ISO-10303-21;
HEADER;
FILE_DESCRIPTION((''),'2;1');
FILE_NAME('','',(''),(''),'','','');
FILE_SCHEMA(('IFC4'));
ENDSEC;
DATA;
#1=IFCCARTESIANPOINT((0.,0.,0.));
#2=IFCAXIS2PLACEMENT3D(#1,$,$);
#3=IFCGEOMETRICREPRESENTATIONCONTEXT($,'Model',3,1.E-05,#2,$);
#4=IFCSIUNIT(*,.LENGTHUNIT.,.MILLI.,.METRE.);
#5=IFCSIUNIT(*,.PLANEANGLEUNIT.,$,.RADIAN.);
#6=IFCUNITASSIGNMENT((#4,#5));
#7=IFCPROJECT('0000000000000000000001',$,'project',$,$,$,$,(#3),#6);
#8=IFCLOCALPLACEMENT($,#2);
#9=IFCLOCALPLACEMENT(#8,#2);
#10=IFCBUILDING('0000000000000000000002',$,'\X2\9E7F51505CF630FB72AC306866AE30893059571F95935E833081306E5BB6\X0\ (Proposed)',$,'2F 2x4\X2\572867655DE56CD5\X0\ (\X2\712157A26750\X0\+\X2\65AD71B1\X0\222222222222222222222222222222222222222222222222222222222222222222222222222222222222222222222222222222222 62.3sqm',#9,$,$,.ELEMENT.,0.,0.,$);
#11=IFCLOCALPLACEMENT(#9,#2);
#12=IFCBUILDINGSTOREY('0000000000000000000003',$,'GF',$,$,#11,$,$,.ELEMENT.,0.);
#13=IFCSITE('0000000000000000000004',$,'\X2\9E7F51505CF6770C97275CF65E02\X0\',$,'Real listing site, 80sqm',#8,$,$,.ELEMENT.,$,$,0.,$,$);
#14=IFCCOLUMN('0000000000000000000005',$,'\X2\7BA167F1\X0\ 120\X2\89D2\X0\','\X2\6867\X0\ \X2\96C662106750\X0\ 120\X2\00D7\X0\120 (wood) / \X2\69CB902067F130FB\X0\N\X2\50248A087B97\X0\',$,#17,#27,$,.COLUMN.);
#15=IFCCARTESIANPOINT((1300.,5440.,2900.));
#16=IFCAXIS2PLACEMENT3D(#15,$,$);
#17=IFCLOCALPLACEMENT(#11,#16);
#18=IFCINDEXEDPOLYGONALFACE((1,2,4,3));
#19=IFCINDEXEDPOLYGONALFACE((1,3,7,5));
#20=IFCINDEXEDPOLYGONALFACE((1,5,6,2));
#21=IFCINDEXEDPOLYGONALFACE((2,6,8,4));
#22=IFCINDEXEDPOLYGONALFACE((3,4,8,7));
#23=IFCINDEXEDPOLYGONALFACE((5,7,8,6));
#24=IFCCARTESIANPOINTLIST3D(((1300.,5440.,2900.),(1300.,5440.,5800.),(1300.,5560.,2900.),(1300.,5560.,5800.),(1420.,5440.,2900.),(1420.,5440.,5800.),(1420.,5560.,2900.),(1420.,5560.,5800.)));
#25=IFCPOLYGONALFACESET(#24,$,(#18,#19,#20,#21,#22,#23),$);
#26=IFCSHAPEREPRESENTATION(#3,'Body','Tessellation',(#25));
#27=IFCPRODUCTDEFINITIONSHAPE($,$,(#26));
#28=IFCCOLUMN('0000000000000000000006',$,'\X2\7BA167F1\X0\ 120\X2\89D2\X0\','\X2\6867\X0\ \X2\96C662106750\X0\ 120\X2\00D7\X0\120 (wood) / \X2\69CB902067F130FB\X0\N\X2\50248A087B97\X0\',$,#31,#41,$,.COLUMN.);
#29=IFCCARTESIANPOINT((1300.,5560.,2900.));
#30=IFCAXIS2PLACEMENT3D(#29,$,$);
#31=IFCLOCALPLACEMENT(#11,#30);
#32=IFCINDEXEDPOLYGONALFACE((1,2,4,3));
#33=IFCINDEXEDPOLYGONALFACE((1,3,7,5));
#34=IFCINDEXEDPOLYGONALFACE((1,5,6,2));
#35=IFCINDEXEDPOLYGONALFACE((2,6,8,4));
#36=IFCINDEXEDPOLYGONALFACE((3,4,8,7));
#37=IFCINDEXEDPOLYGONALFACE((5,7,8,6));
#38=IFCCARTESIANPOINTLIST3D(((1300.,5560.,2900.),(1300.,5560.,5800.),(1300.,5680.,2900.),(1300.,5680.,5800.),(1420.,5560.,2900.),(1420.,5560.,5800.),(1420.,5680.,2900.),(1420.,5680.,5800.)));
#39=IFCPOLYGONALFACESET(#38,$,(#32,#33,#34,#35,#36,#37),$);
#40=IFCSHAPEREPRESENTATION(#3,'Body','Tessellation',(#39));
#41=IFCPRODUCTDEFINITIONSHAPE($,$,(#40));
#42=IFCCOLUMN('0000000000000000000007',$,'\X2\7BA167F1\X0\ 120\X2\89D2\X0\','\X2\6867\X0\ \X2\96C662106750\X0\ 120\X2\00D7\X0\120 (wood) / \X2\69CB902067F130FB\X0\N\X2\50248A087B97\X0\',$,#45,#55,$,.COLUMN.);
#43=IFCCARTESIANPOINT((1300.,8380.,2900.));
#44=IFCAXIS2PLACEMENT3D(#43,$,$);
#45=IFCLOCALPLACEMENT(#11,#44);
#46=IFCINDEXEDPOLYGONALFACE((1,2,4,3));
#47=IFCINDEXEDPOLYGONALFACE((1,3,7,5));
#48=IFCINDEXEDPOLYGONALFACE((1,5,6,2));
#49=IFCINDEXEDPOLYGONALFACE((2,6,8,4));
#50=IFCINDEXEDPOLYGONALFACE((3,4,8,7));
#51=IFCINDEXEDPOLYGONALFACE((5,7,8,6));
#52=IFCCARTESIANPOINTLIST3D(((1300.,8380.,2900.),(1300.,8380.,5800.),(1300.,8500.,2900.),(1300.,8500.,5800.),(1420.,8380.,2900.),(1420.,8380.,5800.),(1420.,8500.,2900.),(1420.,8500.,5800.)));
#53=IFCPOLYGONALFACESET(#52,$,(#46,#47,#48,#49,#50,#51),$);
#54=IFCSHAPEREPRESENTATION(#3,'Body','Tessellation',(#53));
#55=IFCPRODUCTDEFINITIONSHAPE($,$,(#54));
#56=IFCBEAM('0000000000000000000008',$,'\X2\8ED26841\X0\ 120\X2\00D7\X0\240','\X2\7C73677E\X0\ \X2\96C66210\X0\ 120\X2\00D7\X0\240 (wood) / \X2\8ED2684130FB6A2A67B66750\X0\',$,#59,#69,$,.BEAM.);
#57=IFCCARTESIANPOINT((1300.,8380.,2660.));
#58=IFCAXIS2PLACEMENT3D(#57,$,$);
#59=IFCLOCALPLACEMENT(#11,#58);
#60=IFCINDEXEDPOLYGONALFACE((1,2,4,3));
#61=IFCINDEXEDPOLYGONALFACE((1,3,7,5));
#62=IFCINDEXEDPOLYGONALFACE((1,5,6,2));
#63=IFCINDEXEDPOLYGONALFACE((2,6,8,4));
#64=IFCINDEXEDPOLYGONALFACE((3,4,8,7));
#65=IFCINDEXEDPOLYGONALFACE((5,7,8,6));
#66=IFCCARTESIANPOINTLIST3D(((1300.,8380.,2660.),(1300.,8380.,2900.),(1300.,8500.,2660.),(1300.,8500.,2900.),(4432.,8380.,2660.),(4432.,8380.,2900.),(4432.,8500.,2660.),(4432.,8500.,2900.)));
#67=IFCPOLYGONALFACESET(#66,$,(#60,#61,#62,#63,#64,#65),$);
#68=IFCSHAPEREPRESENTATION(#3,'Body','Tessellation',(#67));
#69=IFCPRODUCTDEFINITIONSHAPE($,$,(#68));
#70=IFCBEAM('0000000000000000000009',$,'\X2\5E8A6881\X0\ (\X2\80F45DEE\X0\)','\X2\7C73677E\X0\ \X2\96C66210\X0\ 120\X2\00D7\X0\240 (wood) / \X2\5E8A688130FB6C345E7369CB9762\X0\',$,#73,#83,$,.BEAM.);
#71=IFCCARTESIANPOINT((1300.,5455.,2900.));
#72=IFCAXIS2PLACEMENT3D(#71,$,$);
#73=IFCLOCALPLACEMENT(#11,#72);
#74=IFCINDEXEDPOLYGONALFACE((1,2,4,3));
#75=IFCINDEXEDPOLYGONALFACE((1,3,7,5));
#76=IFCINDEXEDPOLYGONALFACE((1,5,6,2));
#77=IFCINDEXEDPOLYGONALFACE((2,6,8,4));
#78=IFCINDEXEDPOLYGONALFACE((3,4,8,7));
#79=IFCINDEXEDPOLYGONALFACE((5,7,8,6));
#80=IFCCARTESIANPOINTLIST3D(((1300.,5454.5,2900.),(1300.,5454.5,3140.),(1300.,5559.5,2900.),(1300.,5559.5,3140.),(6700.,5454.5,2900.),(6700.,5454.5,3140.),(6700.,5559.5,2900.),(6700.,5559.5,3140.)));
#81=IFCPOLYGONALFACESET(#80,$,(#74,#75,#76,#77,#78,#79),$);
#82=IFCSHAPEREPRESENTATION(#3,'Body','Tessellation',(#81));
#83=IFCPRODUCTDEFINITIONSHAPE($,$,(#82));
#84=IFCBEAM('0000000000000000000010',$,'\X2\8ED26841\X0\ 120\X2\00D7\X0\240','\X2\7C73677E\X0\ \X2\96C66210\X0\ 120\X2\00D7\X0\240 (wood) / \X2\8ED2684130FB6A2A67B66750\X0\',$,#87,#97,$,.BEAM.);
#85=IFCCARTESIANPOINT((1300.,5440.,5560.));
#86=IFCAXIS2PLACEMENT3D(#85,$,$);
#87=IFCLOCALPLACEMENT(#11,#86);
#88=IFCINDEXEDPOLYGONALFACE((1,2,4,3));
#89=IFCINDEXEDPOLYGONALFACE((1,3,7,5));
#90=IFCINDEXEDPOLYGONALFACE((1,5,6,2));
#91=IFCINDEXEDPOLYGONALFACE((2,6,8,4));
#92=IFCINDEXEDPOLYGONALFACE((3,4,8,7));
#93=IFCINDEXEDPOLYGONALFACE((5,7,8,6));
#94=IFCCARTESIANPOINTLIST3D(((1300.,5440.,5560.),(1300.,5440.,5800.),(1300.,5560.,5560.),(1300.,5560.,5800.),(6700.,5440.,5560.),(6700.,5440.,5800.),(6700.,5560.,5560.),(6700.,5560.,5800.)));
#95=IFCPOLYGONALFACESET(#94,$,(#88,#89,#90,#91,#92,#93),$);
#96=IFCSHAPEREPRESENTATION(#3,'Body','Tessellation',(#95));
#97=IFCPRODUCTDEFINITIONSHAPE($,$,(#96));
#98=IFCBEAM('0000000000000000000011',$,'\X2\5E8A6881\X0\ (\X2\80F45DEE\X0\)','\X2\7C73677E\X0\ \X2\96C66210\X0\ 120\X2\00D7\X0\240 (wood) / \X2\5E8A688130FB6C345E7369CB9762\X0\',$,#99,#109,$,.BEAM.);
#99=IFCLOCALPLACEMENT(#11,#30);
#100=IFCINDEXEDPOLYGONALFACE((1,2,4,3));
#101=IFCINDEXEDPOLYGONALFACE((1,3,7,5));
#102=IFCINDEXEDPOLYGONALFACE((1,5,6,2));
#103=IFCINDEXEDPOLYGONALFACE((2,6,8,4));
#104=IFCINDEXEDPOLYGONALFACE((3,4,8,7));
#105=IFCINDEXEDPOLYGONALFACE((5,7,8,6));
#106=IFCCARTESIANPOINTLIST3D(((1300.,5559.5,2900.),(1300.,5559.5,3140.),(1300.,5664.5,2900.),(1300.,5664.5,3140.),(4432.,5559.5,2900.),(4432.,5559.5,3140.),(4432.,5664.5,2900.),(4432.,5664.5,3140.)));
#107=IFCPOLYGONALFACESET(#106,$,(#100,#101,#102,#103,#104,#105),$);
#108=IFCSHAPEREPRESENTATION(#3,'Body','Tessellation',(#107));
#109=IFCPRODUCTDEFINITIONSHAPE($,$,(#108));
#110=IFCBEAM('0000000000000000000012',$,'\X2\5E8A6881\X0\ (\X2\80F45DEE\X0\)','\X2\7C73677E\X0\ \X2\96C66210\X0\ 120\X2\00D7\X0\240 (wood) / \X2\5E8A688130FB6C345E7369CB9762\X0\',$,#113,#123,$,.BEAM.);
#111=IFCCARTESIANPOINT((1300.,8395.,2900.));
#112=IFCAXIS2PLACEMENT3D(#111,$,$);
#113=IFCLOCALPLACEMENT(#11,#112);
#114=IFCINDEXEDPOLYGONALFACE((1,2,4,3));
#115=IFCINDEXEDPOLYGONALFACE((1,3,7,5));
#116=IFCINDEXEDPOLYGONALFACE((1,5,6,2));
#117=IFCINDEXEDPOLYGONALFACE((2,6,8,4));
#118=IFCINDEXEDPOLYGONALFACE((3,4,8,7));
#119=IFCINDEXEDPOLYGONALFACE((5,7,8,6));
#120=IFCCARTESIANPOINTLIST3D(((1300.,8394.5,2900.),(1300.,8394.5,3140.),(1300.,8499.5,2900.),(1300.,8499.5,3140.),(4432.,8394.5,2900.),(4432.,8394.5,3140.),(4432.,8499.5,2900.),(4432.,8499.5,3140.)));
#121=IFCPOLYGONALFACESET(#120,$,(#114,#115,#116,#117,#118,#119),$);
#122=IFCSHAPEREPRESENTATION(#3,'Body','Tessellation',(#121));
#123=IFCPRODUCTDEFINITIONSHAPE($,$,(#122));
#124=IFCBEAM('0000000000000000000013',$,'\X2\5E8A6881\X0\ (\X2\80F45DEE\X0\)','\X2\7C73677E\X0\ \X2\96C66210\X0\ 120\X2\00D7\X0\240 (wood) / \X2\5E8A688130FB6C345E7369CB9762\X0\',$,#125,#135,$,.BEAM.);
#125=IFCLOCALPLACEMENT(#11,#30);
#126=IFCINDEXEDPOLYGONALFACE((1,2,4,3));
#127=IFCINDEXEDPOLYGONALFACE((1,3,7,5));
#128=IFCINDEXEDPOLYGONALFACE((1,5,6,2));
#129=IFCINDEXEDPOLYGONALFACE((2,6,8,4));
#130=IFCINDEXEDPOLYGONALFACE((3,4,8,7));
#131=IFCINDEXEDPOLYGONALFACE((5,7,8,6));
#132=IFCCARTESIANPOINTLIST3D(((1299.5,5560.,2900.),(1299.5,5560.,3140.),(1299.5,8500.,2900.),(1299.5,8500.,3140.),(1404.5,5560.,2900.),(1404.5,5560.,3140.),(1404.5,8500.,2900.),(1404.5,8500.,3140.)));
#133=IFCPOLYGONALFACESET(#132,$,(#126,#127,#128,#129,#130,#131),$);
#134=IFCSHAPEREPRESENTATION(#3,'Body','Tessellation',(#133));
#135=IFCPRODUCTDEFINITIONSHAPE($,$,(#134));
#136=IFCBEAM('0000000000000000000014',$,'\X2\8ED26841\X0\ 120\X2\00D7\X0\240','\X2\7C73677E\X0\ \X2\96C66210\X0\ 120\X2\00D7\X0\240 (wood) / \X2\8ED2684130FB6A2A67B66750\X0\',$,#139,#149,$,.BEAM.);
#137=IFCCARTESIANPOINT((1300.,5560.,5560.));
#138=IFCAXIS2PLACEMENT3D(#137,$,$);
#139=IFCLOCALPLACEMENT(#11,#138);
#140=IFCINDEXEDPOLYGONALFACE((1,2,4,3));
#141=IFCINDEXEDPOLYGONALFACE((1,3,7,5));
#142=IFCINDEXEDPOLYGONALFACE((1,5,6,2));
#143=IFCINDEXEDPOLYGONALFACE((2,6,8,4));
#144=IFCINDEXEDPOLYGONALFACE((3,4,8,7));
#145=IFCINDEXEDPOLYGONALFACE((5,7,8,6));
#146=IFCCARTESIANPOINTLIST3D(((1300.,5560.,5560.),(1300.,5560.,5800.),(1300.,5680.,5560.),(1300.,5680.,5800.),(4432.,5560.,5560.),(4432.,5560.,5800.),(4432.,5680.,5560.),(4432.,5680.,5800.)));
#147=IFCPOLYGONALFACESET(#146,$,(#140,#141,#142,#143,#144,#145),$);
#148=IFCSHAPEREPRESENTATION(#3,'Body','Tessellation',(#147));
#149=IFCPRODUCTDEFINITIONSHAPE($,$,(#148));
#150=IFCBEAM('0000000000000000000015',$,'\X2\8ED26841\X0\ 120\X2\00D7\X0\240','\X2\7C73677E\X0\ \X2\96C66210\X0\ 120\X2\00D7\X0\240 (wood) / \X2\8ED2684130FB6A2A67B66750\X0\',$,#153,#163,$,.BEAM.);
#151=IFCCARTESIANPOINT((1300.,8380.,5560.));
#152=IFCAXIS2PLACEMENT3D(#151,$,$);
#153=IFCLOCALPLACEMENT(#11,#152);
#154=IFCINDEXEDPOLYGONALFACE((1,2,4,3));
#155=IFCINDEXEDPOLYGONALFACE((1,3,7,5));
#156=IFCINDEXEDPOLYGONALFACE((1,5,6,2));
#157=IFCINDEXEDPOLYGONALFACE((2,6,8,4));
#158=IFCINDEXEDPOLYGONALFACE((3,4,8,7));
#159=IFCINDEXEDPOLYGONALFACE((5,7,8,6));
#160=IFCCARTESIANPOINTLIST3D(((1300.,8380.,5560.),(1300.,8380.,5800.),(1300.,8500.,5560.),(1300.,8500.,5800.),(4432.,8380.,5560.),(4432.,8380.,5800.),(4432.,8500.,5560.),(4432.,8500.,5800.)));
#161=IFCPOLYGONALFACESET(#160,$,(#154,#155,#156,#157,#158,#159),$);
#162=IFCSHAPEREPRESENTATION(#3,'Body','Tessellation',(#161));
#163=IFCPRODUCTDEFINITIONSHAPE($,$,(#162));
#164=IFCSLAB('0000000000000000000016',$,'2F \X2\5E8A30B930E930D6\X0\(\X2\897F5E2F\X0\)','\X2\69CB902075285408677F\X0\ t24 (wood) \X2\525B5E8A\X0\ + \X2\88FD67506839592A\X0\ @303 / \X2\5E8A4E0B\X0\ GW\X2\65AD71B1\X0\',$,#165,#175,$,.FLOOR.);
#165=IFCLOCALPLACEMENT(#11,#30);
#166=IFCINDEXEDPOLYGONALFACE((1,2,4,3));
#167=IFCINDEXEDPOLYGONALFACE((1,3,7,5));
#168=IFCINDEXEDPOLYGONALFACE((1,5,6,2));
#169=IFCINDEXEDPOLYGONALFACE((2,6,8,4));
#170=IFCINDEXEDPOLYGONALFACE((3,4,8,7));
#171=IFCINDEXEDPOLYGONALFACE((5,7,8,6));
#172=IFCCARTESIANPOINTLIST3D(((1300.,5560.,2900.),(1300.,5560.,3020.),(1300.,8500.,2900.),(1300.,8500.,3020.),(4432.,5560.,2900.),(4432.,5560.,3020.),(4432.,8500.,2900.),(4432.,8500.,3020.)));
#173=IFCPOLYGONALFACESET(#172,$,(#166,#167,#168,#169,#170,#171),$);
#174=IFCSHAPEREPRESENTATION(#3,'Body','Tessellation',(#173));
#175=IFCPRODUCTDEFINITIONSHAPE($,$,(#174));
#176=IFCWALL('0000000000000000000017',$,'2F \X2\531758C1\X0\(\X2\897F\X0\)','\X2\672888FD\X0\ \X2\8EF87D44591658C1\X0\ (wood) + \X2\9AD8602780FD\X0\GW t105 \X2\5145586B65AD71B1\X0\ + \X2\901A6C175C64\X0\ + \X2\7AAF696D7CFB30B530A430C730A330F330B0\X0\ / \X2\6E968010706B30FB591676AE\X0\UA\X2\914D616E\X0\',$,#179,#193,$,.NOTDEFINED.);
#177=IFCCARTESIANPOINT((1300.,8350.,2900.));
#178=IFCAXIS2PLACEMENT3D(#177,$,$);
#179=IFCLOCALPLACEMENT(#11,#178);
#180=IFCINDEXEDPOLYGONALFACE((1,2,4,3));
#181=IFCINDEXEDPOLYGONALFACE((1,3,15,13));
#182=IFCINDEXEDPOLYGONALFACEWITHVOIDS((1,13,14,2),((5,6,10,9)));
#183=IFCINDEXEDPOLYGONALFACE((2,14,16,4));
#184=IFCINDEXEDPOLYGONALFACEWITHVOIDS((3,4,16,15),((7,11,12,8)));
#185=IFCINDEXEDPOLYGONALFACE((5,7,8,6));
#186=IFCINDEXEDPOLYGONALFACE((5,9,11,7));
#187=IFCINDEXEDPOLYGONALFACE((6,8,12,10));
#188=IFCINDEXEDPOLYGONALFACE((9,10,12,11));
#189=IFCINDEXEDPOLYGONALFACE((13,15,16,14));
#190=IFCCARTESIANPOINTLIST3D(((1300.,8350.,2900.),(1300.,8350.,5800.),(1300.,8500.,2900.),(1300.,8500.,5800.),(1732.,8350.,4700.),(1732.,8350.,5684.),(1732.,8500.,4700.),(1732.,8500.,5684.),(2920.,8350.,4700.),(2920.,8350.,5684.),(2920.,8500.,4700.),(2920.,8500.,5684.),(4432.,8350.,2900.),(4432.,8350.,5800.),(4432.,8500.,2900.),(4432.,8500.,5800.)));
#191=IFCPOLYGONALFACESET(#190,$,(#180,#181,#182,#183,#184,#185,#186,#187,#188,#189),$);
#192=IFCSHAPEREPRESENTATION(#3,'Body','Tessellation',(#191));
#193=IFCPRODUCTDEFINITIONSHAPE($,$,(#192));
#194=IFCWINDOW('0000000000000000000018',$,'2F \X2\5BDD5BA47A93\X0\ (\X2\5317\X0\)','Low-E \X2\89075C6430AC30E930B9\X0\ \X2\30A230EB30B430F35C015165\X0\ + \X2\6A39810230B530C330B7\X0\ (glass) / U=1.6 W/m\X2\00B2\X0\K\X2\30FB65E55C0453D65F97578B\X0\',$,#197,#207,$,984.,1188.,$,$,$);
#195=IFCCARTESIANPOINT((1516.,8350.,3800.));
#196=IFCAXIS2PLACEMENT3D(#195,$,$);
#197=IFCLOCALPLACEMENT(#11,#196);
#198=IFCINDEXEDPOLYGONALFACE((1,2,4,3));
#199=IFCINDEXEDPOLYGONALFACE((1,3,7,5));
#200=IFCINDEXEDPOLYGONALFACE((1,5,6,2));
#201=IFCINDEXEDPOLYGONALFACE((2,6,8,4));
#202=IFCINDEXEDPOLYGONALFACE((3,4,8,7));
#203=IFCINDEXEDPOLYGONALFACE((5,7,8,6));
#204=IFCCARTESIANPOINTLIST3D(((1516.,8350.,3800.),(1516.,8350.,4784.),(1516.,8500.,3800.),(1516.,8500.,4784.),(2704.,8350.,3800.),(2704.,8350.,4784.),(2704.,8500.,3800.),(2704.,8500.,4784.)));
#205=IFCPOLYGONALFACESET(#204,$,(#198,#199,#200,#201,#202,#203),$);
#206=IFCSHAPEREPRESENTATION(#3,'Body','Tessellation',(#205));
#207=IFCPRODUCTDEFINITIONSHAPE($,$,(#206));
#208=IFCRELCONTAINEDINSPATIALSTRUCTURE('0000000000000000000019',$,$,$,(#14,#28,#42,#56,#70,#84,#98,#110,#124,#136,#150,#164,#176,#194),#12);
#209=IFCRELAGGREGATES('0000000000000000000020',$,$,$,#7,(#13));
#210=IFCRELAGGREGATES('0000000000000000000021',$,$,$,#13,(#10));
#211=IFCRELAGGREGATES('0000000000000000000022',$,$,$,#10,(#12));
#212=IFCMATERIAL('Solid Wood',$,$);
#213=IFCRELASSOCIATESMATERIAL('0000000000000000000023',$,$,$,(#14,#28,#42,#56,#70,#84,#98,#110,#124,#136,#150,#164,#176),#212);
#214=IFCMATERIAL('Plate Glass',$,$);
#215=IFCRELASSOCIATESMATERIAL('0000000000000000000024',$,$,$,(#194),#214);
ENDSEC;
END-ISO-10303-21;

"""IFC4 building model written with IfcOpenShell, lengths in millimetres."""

from ifc_helpers import new_model, si_unit, frame, frame_2d, origin, place, context, project, spatial, rectangle, extrude, material, element, fill, save


model = new_model("IFC4")

# Units and contexts
model_context = context("Model", 3, precision=1e-05, world=origin())
ifc_project = project(units=[si_unit("LENGTHUNIT", "METRE", prefix="MILLI"), si_unit("PLANEANGLEUNIT", "RADIAN")], contexts=[model_context])

# Site, building, storey
site_placement = place(None, origin())
site = spatial("IfcSite", under=ifc_project, at=site_placement, Name="鹿児島県霧島市", ObjectType="Real listing site, 80sqm", CompositionType="ELEMENT", RefElevation=0.0)
building_placement = place(site_placement, origin())
building = spatial("IfcBuilding", under=site, at=building_placement, Name="鹿児島・犬と暮らす土間広めの家 (Proposed)", ObjectType="2F 2x4在来工法 (無垢材+断熱222222222222222222222222222222222222222222222222222222222222222222222222222222222222222222222222222222222 62.3sqm", CompositionType="ELEMENT", ElevationOfRefHeight=0.0, ElevationOfTerrain=0.0)
storey_placement = place(building_placement, origin())
storey = spatial("IfcBuildingStorey", under=building, at=storey_placement, Name="GF", CompositionType="ELEMENT", Elevation=0.0)

# Columns
ifc_material_1 = material(Name="Solid Wood")
column_1_placement = place(storey_placement, frame((1300.0, 5440.0, 2900.0)))
element("IfcColumn", 1, at=column_1_placement, inside=storey, material=ifc_material_1, Name="管柱 120角", Description="桧 集成材 120×120 (wood) / 構造柱・N値計算", PredefinedType="COLUMN", context=model_context, shape_type="SweptSolid", body=[
    extrude(rectangle(XDim=120.0, YDim=120.0, at=frame_2d((60.0, 60.0))), frame((1300.0, 5440.0, 2900.0)), (0.0, 0.0, 1.0), 2900.0),
])
column_2_placement = place(storey_placement, frame((1300.0, 5560.0, 2900.0)))
element("IfcColumn", 2, at=column_2_placement, inside=storey, material=ifc_material_1, Name="管柱 120角", Description="桧 集成材 120×120 (wood) / 構造柱・N値計算", PredefinedType="COLUMN", context=model_context, shape_type="SweptSolid", body=[
    extrude(rectangle(XDim=120.0, YDim=120.0, at=frame_2d((60.0, 60.0))), frame((1300.0, 5560.0, 2900.0)), (0.0, 0.0, 1.0), 2900.0),
])
column_3_placement = place(storey_placement, frame((1300.0, 8380.0, 2900.0)))
element("IfcColumn", 3, at=column_3_placement, inside=storey, material=ifc_material_1, Name="管柱 120角", Description="桧 集成材 120×120 (wood) / 構造柱・N値計算", PredefinedType="COLUMN", context=model_context, shape_type="SweptSolid", body=[
    extrude(rectangle(XDim=120.0, YDim=120.0, at=frame_2d((60.0, 60.0))), frame((1300.0, 8380.0, 2900.0)), (0.0, 0.0, 1.0), 2900.0),
])

# Beams
beam_1_placement = place(storey_placement, frame((1300.0, 8380.0, 2660.0)))
element("IfcBeam", 4, at=beam_1_placement, inside=storey, material=ifc_material_1, Name="軒桁 120×240", Description="米松 集成 120×240 (wood) / 軒桁・横架材", PredefinedType="BEAM", context=model_context, shape_type="SweptSolid", body=[
    extrude(rectangle(XDim=3132.0, YDim=120.0, at=frame_2d((1566.0, 60.0))), frame((1300.0, 8380.0, 2660.0)), (0.0, 0.0, 1.0), 240.0),
])
beam_2_placement = place(storey_placement, frame((1300.0, 5455.0, 2900.0)))
element("IfcBeam", 5, at=beam_2_placement, inside=storey, material=ifc_material_1, Name="床梁 (胴差)", Description="米松 集成 120×240 (wood) / 床梁・水平構面", PredefinedType="BEAM", context=model_context, shape_type="SweptSolid", body=[
    extrude(rectangle(XDim=5400.0, YDim=105.0, at=frame_2d((2700.0, 52.0))), frame((1300.0, 5455.0, 2900.0)), (0.0, 0.0, 1.0), 240.0),
])
beam_3_placement = place(storey_placement, frame((1300.0, 5440.0, 5560.0)))
element("IfcBeam", 6, at=beam_3_placement, inside=storey, material=ifc_material_1, Name="軒桁 120×240", Description="米松 集成 120×240 (wood) / 軒桁・横架材", PredefinedType="BEAM", context=model_context, shape_type="SweptSolid", body=[
    extrude(rectangle(XDim=5400.0, YDim=120.0, at=frame_2d((2700.0, 60.0))), frame((1300.0, 5440.0, 5560.0)), (0.0, 0.0, 1.0), 240.0),
])
beam_4_placement = place(storey_placement, frame((1300.0, 5560.0, 2900.0)))
element("IfcBeam", 7, at=beam_4_placement, inside=storey, material=ifc_material_1, Name="床梁 (胴差)", Description="米松 集成 120×240 (wood) / 床梁・水平構面", PredefinedType="BEAM", context=model_context, shape_type="SweptSolid", body=[
    extrude(rectangle(XDim=3132.0, YDim=105.0, at=frame_2d((1566.0, 52.0))), frame((1300.0, 5560.0, 2900.0)), (0.0, 0.0, 1.0), 240.0),
])
beam_5_placement = place(storey_placement, frame((1300.0, 8395.0, 2900.0)))
element("IfcBeam", 8, at=beam_5_placement, inside=storey, material=ifc_material_1, Name="床梁 (胴差)", Description="米松 集成 120×240 (wood) / 床梁・水平構面", PredefinedType="BEAM", context=model_context, shape_type="SweptSolid", body=[
    extrude(rectangle(XDim=3132.0, YDim=105.0, at=frame_2d((1566.0, 52.0))), frame((1300.0, 8395.0, 2900.0)), (0.0, 0.0, 1.0), 240.0),
])
beam_6_placement = place(storey_placement, frame((1300.0, 5560.0, 2900.0)))
element("IfcBeam", 9, at=beam_6_placement, inside=storey, material=ifc_material_1, Name="床梁 (胴差)", Description="米松 集成 120×240 (wood) / 床梁・水平構面", PredefinedType="BEAM", context=model_context, shape_type="SweptSolid", body=[
    extrude(rectangle(XDim=105.0, YDim=2940.0, at=frame_2d((52.0, 1470.0))), frame((1300.0, 5560.0, 2900.0)), (0.0, 0.0, 1.0), 240.0),
])
beam_7_placement = place(storey_placement, frame((1300.0, 5560.0, 5560.0)))
element("IfcBeam", 10, at=beam_7_placement, inside=storey, material=ifc_material_1, Name="軒桁 120×240", Description="米松 集成 120×240 (wood) / 軒桁・横架材", PredefinedType="BEAM", context=model_context, shape_type="SweptSolid", body=[
    extrude(rectangle(XDim=3132.0, YDim=120.0, at=frame_2d((1566.0, 60.0))), frame((1300.0, 5560.0, 5560.0)), (0.0, 0.0, 1.0), 240.0),
])
beam_8_placement = place(storey_placement, frame((1300.0, 8380.0, 5560.0)))
element("IfcBeam", 11, at=beam_8_placement, inside=storey, material=ifc_material_1, Name="軒桁 120×240", Description="米松 集成 120×240 (wood) / 軒桁・横架材", PredefinedType="BEAM", context=model_context, shape_type="SweptSolid", body=[
    extrude(rectangle(XDim=3132.0, YDim=120.0, at=frame_2d((1566.0, 60.0))), frame((1300.0, 8380.0, 5560.0)), (0.0, 0.0, 1.0), 240.0),
])

# Slab
slab_placement = place(storey_placement, frame((1300.0, 5560.0, 2900.0)))
element("IfcSlab", 12, at=slab_placement, inside=storey, material=ifc_material_1, Name="2F 床スラブ(西帯)", Description="構造用合板 t24 (wood) 剛床 + 製材根太 @303 / 床下 GW断熱", PredefinedType="FLOOR", context=model_context, shape_type="SweptSolid", body=[
    extrude(rectangle(XDim=3132.0, YDim=2940.0, at=frame_2d((1566.0, 1470.0))), frame((1300.0, 5560.0, 2900.0)), (0.0, 0.0, 1.0), 120.0),
])

# Wall, opening, window
wall_1_placement = place(storey_placement, frame((1300.0, 8350.0, 2900.0)))
wall_1 = element("IfcWall", 13, at=wall_1_placement, inside=storey, material=ifc_material_1, Name="2F 北壁(西)", Description="木製 軸組外壁 (wood) + 高性能GW t105 充填断熱 + 通気層 + 窯業系サイディング / 準耐火・外皮UA配慮", PredefinedType="NOTDEFINED", context=model_context, shape_type="SweptSolid", body=[
    extrude(rectangle(XDim=3132.0, YDim=150.0, at=frame_2d((1566.0, 75.0))), frame((1300.0, 8350.0, 2900.0)), (0.0, 0.0, 1.0), 2900.0),
])
opening_placement = place(storey_placement, frame((1516.0, 8350.0, 3800.0)))
opening = element("IfcOpeningElement", 14, at=opening_placement, cuts=wall_1, PredefinedType="NOTDEFINED", context=model_context, shape_type="SweptSolid", body=[
    extrude(rectangle(XDim=1188.0, YDim=150.0, at=frame_2d((594.0, 75.0))), frame((1516.0, 8350.0, 3800.0)), (0.0, 0.0, 1.0), 984.0),
])
ifc_material_2 = material(Name="Plate Glass")
window_placement = place(storey_placement, frame((1516.0, 8350.0, 3800.0)))
window = element("IfcWindow", 15, at=window_placement, inside=storey, material=ifc_material_2, Name="2F 寝室窓 (北)", Description="Low-E 複層ガラス アルゴン封入 + 樹脂サッシ (glass) / U=1.6 W/m²K・日射取得型", OverallHeight=984.0, OverallWidth=1188.0, context=model_context, shape_type="SweptSolid", body=[
    extrude(rectangle(XDim=1188.0, YDim=150.0, at=frame_2d((594.0, 75.0))), frame((1516.0, 8350.0, 3800.0)), (0.0, 0.0, 1.0), 984.0),
])
fill(opening, window)

save(model, "model.ifc")
